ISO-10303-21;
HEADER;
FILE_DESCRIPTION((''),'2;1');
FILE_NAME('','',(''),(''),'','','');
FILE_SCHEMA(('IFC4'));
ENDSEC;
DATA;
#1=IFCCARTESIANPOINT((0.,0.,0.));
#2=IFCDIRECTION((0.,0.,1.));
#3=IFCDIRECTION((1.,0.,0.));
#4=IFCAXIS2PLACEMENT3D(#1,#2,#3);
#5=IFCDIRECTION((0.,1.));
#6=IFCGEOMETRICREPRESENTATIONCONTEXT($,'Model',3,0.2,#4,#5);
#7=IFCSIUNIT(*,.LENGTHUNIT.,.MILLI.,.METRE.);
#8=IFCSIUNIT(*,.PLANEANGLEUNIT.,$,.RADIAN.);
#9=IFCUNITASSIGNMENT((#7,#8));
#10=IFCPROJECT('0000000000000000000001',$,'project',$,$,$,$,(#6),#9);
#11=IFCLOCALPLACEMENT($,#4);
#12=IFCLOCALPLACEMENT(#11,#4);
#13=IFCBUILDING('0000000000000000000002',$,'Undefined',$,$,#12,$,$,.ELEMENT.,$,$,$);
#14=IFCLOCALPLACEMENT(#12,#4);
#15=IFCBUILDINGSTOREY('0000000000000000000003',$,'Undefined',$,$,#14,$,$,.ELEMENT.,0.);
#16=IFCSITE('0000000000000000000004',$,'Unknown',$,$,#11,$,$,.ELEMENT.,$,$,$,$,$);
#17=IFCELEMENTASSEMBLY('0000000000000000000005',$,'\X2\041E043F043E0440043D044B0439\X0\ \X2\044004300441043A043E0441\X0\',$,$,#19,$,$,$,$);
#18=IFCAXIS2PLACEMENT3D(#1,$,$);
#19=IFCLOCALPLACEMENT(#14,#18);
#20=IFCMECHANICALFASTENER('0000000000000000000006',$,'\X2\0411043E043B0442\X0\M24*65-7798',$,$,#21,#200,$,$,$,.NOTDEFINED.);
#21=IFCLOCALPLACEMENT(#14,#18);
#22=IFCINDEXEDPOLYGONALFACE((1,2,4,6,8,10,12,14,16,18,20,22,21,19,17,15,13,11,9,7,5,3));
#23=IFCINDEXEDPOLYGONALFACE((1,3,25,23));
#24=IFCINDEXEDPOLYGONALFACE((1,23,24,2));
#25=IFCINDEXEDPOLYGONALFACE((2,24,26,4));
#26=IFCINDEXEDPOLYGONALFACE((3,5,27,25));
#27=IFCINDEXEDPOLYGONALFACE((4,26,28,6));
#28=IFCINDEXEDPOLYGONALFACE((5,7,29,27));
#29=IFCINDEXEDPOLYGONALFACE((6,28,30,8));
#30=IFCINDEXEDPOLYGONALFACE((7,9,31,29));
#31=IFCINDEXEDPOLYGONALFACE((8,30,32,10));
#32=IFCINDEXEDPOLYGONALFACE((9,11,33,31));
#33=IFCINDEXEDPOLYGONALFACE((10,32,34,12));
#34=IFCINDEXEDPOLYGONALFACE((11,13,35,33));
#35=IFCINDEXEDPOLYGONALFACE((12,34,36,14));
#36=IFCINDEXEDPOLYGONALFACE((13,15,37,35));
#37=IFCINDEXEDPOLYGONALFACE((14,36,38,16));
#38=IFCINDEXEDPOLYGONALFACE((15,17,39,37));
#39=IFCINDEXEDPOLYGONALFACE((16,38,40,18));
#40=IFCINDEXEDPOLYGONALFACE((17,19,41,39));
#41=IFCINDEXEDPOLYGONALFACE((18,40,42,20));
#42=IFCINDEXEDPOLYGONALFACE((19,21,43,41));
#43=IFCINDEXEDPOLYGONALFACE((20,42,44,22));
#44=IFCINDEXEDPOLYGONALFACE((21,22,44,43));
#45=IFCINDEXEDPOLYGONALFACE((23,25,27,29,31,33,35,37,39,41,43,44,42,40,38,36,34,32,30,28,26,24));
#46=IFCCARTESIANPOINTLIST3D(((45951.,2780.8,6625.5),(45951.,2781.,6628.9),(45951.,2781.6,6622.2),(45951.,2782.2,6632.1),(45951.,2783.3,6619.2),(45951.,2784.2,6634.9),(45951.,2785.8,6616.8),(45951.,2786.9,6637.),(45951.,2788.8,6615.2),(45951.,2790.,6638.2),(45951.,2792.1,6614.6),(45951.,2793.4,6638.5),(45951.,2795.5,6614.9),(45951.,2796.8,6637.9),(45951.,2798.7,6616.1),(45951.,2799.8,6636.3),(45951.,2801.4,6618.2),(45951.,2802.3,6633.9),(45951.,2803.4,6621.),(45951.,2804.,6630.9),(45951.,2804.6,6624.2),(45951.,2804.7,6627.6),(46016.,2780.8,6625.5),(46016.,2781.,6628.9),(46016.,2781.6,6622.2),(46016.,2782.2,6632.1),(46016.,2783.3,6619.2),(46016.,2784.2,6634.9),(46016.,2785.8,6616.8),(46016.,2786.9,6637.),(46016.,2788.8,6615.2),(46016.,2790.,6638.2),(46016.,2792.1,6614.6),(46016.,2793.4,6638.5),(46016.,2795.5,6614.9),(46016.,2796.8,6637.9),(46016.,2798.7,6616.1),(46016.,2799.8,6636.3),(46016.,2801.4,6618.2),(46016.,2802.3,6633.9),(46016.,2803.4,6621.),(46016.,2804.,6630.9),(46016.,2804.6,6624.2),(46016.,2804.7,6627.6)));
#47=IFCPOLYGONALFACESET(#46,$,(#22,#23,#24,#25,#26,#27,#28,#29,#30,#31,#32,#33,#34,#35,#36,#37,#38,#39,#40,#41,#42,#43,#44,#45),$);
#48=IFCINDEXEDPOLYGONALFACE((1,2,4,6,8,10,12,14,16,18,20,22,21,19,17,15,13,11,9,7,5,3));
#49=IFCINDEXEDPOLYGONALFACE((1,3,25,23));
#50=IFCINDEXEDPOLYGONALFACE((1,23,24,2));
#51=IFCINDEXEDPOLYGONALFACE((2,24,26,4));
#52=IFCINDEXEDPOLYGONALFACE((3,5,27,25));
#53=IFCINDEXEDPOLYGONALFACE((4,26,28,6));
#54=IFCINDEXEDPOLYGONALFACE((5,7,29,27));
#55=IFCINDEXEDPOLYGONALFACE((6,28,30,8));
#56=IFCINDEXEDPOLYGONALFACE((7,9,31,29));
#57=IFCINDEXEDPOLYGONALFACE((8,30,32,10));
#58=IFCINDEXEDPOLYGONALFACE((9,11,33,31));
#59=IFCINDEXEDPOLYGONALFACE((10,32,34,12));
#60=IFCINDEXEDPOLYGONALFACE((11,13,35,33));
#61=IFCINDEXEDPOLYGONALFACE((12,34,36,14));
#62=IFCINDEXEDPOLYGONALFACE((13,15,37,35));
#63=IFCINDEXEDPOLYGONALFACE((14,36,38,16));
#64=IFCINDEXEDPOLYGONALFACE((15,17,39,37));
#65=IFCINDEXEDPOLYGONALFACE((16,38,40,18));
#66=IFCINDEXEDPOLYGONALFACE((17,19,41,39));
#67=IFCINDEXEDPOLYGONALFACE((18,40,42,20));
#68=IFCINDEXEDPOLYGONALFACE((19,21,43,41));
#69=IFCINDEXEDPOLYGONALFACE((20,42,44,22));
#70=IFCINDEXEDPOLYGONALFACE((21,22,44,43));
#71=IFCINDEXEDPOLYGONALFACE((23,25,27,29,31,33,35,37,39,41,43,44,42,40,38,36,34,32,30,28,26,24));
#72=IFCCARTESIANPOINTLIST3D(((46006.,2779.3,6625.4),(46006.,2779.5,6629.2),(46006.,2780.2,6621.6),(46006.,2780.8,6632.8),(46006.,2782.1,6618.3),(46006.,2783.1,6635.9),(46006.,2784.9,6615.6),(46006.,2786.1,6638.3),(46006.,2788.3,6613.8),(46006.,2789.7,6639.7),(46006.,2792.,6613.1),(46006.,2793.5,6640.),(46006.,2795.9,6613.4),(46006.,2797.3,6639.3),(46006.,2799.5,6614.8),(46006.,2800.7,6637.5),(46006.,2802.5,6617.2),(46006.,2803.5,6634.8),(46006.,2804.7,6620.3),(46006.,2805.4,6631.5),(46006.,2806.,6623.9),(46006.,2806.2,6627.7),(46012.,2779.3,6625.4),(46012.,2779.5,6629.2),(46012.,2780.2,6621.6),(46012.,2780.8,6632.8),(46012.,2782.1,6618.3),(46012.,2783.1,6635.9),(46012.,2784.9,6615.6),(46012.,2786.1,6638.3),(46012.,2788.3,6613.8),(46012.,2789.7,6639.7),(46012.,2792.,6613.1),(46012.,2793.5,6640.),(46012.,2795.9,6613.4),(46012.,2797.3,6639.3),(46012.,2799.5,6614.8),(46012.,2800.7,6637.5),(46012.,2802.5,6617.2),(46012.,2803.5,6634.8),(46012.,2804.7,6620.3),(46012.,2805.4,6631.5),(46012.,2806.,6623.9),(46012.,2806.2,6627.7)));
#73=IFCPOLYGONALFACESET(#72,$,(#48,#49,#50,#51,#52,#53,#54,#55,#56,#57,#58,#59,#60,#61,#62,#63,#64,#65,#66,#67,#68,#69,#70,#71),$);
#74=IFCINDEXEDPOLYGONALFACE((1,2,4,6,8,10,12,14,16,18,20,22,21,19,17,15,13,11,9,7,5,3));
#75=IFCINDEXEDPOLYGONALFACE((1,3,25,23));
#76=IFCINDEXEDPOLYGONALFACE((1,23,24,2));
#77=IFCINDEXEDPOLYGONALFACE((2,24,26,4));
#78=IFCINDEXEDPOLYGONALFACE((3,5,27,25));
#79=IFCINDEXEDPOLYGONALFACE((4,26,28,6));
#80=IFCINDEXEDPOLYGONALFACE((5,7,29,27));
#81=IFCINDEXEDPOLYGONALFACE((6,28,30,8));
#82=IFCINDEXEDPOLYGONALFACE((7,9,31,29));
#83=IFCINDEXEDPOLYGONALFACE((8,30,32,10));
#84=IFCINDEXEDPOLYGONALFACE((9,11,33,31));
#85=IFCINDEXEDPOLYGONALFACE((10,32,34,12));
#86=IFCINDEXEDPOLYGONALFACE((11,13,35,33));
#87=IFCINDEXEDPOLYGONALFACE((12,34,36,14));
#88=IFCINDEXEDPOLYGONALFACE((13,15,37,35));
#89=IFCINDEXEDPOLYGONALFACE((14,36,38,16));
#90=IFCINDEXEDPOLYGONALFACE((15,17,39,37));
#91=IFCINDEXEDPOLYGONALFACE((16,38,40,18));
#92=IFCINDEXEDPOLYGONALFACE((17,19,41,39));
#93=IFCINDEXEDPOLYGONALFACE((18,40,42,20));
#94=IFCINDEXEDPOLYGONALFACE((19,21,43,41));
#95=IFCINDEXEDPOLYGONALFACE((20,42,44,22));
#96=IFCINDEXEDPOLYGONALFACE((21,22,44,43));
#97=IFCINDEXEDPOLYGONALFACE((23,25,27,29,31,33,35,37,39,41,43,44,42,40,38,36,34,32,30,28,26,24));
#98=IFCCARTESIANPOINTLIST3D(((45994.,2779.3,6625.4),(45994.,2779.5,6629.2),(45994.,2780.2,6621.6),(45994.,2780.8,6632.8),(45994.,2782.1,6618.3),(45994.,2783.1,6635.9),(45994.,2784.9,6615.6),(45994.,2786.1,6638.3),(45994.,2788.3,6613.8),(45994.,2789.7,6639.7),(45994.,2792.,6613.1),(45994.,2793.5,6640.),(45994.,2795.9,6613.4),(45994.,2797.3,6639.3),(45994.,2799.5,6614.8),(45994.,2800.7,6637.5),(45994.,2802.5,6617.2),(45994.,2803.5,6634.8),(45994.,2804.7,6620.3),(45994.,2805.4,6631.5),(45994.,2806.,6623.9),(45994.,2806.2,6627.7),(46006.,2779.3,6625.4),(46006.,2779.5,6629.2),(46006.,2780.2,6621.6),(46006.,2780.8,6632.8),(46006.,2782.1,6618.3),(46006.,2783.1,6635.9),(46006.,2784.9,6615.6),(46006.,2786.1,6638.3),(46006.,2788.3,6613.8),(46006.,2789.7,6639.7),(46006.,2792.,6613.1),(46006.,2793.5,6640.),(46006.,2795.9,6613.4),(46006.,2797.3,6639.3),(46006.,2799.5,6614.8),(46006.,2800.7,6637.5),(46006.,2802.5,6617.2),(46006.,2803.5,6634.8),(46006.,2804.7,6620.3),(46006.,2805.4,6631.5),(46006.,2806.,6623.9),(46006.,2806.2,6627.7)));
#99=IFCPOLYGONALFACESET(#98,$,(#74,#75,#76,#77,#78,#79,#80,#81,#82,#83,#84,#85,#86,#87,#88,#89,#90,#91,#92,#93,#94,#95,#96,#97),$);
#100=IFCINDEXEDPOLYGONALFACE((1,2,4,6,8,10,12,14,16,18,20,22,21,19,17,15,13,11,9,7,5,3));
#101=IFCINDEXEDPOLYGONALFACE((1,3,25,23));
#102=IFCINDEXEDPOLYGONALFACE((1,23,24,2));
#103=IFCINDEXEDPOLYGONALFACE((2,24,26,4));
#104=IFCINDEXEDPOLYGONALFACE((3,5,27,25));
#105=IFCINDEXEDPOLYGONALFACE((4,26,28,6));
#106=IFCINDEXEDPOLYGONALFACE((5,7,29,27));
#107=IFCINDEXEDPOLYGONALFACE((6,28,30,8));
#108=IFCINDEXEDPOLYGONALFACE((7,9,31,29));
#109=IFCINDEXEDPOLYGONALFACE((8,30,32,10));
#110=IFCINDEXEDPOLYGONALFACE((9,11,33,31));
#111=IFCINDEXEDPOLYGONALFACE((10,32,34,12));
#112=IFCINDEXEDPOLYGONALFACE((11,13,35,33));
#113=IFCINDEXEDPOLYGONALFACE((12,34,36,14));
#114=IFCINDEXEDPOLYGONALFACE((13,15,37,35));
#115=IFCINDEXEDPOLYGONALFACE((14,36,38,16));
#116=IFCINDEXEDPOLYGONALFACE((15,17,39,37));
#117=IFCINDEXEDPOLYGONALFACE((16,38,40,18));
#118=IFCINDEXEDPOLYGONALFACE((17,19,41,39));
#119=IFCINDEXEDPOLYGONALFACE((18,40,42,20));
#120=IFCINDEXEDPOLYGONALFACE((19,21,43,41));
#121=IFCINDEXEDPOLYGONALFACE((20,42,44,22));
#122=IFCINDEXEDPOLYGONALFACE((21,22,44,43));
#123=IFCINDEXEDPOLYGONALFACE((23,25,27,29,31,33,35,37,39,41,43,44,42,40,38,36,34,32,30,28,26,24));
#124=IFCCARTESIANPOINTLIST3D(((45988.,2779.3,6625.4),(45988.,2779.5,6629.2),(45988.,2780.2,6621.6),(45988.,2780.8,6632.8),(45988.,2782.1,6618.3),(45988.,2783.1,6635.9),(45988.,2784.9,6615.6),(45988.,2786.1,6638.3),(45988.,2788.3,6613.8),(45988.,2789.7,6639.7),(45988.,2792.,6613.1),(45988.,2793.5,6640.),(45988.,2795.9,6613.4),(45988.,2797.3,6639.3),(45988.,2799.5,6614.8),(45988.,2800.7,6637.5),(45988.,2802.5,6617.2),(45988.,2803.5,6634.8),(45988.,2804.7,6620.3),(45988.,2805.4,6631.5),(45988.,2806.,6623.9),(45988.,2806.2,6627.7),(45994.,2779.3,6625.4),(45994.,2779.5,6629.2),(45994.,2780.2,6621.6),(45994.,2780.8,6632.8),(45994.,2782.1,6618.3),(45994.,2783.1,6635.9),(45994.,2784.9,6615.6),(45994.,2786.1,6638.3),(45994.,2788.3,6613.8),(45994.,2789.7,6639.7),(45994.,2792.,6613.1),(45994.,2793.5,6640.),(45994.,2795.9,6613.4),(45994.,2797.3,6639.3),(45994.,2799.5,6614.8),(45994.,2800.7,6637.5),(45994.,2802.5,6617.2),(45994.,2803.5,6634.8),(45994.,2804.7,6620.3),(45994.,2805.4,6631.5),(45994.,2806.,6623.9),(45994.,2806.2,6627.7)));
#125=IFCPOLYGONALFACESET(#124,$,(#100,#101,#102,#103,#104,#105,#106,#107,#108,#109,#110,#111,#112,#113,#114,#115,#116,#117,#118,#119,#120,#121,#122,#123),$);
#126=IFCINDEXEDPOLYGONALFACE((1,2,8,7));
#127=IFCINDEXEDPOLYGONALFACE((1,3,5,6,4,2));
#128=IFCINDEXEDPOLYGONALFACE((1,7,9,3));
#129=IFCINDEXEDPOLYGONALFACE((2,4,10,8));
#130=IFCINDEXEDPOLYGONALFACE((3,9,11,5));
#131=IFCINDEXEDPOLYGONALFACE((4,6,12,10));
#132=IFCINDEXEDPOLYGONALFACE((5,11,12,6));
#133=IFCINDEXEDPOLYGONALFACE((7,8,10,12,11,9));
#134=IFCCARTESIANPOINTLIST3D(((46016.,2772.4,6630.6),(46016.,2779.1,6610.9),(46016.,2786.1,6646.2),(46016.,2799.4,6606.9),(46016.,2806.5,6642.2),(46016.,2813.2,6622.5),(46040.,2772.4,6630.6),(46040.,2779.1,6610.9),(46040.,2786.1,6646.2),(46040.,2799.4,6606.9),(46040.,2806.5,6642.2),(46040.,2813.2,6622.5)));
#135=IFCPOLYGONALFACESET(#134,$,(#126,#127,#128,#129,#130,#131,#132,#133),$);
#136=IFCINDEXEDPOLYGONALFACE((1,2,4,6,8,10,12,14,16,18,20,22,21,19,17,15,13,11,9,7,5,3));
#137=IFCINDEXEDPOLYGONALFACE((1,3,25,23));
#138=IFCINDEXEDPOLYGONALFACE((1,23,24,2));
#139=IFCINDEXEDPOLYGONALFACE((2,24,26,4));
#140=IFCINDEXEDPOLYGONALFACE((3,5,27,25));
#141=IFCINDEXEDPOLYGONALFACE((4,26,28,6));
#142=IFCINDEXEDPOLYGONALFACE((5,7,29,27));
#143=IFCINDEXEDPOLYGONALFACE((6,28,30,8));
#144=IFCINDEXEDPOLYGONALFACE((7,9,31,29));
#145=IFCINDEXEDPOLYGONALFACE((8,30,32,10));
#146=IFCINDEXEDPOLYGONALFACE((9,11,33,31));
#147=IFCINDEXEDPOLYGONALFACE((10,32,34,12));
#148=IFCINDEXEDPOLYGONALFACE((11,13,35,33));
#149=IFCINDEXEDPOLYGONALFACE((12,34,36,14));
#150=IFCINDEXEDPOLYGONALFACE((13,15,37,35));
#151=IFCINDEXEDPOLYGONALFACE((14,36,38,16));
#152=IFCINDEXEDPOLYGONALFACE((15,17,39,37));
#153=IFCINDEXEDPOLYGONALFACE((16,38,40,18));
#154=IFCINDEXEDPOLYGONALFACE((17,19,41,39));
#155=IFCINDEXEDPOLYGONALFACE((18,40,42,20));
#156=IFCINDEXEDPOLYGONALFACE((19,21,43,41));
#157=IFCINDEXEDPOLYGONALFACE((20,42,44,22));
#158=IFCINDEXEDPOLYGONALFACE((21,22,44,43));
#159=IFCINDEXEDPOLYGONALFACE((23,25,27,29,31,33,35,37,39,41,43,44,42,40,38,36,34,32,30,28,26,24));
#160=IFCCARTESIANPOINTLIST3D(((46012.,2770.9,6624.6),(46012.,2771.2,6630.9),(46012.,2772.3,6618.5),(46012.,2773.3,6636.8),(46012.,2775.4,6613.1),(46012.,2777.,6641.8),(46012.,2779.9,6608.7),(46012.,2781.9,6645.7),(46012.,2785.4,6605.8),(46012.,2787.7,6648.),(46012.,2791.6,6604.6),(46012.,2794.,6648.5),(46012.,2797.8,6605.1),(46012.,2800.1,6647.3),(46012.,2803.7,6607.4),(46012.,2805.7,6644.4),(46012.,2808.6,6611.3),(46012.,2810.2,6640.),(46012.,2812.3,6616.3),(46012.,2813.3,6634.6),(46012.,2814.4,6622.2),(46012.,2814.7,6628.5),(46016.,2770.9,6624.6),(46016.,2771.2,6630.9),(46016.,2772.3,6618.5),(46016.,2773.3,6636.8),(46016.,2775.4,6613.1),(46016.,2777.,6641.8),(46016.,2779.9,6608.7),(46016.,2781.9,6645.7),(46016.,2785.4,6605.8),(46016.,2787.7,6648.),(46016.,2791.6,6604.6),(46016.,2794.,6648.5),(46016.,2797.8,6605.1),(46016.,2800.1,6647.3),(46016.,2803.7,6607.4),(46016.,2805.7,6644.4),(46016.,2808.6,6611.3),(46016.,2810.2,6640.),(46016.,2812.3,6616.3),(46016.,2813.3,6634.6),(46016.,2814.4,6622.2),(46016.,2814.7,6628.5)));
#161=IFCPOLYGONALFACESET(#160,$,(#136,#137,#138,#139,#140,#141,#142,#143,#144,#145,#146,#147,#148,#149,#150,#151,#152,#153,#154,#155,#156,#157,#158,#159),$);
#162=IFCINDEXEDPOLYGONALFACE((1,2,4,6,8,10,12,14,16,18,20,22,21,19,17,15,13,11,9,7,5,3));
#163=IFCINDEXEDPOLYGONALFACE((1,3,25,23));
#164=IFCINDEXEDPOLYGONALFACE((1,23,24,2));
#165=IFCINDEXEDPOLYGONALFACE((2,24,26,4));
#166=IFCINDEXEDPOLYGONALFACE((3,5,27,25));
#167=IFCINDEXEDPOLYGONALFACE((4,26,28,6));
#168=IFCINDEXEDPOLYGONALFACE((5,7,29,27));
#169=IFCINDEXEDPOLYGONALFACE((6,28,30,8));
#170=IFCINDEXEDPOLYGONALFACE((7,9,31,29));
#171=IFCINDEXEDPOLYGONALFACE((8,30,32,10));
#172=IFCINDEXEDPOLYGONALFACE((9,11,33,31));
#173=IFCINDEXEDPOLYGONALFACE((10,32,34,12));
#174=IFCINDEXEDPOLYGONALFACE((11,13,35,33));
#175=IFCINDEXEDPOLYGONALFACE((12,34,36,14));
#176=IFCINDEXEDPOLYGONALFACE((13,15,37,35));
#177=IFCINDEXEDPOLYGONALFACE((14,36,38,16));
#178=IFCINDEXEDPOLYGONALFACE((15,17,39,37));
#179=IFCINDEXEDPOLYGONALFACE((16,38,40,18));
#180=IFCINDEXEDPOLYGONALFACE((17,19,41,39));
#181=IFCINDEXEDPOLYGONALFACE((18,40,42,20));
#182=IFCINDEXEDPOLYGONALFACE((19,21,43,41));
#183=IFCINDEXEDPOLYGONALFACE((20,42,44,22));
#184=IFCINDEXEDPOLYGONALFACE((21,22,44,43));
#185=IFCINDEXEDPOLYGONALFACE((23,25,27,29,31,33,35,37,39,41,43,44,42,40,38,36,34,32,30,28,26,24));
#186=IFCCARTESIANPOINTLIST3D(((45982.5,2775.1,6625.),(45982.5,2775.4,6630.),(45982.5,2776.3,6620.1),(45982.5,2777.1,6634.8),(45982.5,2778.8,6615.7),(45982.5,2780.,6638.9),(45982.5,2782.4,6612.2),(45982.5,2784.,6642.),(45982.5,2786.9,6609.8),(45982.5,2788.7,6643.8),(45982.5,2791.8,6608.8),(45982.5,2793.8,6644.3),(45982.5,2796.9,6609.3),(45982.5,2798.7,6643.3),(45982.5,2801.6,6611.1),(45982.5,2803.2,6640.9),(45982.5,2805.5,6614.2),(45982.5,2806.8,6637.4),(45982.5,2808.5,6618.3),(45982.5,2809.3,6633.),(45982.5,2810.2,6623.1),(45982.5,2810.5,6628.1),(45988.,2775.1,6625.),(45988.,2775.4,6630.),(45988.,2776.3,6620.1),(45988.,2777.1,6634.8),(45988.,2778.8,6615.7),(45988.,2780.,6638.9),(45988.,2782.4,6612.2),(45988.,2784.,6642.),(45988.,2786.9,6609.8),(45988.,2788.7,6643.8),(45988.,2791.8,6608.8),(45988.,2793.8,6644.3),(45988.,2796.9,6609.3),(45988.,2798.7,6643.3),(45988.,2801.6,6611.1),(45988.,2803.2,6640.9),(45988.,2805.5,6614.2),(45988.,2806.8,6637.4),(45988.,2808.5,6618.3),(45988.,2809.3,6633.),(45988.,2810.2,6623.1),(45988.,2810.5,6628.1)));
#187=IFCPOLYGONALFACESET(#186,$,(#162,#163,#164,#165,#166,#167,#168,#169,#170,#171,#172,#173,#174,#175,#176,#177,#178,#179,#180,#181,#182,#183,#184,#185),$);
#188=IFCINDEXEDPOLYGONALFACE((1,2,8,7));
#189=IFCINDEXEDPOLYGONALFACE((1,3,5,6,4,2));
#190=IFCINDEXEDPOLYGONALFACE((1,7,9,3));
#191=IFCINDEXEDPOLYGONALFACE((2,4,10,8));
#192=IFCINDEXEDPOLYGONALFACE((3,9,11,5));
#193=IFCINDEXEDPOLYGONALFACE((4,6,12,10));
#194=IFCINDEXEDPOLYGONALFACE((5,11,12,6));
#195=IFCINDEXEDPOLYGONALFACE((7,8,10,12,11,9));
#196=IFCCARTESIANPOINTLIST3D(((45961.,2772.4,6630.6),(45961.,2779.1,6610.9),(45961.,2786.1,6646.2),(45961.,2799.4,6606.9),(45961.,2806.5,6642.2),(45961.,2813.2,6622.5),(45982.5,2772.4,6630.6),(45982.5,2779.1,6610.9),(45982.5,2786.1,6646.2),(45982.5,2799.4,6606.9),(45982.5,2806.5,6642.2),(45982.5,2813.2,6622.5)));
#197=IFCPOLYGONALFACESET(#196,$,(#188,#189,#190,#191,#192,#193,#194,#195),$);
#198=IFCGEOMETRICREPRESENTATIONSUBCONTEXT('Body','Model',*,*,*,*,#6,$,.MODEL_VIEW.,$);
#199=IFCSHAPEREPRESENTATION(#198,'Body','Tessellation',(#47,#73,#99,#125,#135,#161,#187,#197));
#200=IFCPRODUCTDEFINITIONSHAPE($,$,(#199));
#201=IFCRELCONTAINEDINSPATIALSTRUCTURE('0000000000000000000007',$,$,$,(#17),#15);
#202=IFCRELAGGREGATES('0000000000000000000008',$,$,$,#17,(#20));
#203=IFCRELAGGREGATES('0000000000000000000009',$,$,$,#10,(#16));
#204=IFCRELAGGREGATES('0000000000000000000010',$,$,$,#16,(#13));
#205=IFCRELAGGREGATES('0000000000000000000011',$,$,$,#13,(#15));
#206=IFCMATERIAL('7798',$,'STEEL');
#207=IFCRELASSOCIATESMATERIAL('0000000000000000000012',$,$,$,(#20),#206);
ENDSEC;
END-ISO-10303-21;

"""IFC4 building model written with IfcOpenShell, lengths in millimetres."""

from ifc_helpers import new_model, si_unit, direction, frame, origin_with_axes, place, context, subcontext, project, spatial, line, arc, indexed_curve, outline, extrude, source, transform, mapped, material, element, aggregate, save


model = new_model("IFC4")

# Units and contexts
model_context = context("Model", 3, precision=0.2, world=origin_with_axes(), true_north=direction((0.0, 1.0)))
body_context = subcontext(model_context, "Body", "Model", "MODEL_VIEW")
ifc_project = project(units=[si_unit("LENGTHUNIT", "METRE", prefix="MILLI"), si_unit("PLANEANGLEUNIT", "RADIAN")], contexts=[model_context])

# Site, building, storey
site_placement = place(None, origin_with_axes())
site = spatial("IfcSite", under=ifc_project, at=site_placement, Name="Unknown", CompositionType="ELEMENT")
building_placement = place(site_placement, origin_with_axes())
building = spatial("IfcBuilding", under=site, at=building_placement, Name="Undefined", CompositionType="ELEMENT")
storey_placement = place(building_placement, origin_with_axes())
storey = spatial("IfcBuildingStorey", under=building, at=storey_placement, Name="Undefined", CompositionType="ELEMENT", Elevation=0.0)

# Shared definitions
ifc_material_1 = material(Name="7798", Category="STEEL")

# Element assembly, mechanical fastener
assembly_1_placement = place(storey_placement, frame((45949.0, 350.1, 7110.0), z_axis=(0.0, 0.196116, 0.980581), x_axis=(0.0, 0.980581, -0.196116)))
assembly_1 = element("IfcElementAssembly", 1, at=assembly_1_placement, inside=storey, Name="Опорный раскос")
shared_shape_1 = source(origin_with_axes(), body_context, "Body", "SweptSolid", [
    extrude(outline(indexed_curve([(12.0, 0.0), (0.0, 12.0), (-12.0, 0.0), (0.0, -12.0)], segments=[arc(1, 2, 3), arc(3, 4, 1)])), frame((0.0, 0.0, 16.0), z_axis=(0.0, 0.0, -1.0), x_axis=(0.0, 1.0, 0.0)), (0.0, 0.0, 1.0), 65.0),
    extrude(outline(indexed_curve([(13.5, 0.0), (0.0, 13.5), (-13.5, 0.0), (0.0, -13.5)], segments=[arc(1, 2, 3), arc(3, 4, 1)])), frame((0.0, 0.0, 12.0), z_axis=(0.0, 0.0, -1.0), x_axis=(0.0, 1.0, 0.0)), (0.0, 0.0, 1.0), 6.0),
    extrude(outline(indexed_curve([(13.5, 0.0), (0.0, 13.5), (-13.5, 0.0), (0.0, -13.5)], segments=[arc(1, 2, 3), arc(3, 4, 1)])), frame((0.0, 0.0, 6.0), z_axis=(0.0, 0.0, -1.0), x_axis=(0.0, 1.0, 0.0)), (0.0, 0.0, 1.0), 12.0),
    extrude(outline(indexed_curve([(13.5, 0.0), (0.0, 13.5), (-13.5, 0.0), (0.0, -13.5)], segments=[arc(1, 2, 3), arc(3, 4, 1)])), frame((0.0, 0.0, -6.0), z_axis=(0.0, 0.0, -1.0), x_axis=(0.0, 1.0, 0.0)), (0.0, 0.0, 1.0), 6.0),
    extrude(outline(indexed_curve([(20.8, 0.0), (10.4, 18.0), (-10.4, 18.0), (-20.8, 0.0), (-10.4, -18.0), (10.4, -18.0)], segments=[line(1, 2, 3, 4, 5, 6, 1)])), frame((0.0, 0.0, 40.0), z_axis=(0.0, 0.0, -1.0), x_axis=(0.0, 1.0, 0.0)), (0.0, 0.0, 1.0), 24.0),
    extrude(outline(indexed_curve([(22.0, 0.0), (0.0, 22.0), (-22.0, 0.0), (0.0, -22.0)], segments=[arc(1, 2, 3), arc(3, 4, 1)])), frame((0.0, 0.0, 16.0), z_axis=(0.0, 0.0, -1.0), x_axis=(0.0, 1.0, 0.0)), (0.0, 0.0, 1.0), 4.0),
    extrude(outline(indexed_curve([(17.8, 0.0), (0.0, 17.8), (-17.8, 0.0), (0.0, -17.8)], segments=[arc(1, 2, 3), arc(3, 4, 1)])), frame((0.0, 0.0, -12.0), z_axis=(0.0, 0.0, -1.0), x_axis=(0.0, 1.0, 0.0)), (0.0, 0.0, 1.0), 5.5),
    extrude(outline(indexed_curve([(20.8, 0.0), (10.4, 18.0), (-10.4, 18.0), (-20.8, 0.0), (-10.4, -18.0), (10.4, -18.0)], segments=[line(1, 2, 3, 4, 5, 6, 1)])), frame((0.0, 0.0, -17.5), z_axis=(0.0, 0.0, -1.0), x_axis=(0.0, 1.0, 0.0)), (0.0, 0.0, 1.0), 21.5),
])
mechanical_fastener_1_placement = place(assembly_1_placement, frame((2490.1, -51.0, 5.0), z_axis=(0.0, -1.0, 0.0), x_axis=(0.0, 0.0, 1.0)))
mechanical_fastener_1 = element("IfcMechanicalFastener", 2, at=mechanical_fastener_1_placement, material=ifc_material_1, Name="БолтM24*65-7798", PredefinedType="NOTDEFINED", context=body_context, shape_type="MappedRepresentation", body=[
    mapped(shared_shape_1, transform((0.0, 0.0, 0.0))),
])
aggregate(assembly_1, [mechanical_fastener_1])

save(model, "model.ifc")
